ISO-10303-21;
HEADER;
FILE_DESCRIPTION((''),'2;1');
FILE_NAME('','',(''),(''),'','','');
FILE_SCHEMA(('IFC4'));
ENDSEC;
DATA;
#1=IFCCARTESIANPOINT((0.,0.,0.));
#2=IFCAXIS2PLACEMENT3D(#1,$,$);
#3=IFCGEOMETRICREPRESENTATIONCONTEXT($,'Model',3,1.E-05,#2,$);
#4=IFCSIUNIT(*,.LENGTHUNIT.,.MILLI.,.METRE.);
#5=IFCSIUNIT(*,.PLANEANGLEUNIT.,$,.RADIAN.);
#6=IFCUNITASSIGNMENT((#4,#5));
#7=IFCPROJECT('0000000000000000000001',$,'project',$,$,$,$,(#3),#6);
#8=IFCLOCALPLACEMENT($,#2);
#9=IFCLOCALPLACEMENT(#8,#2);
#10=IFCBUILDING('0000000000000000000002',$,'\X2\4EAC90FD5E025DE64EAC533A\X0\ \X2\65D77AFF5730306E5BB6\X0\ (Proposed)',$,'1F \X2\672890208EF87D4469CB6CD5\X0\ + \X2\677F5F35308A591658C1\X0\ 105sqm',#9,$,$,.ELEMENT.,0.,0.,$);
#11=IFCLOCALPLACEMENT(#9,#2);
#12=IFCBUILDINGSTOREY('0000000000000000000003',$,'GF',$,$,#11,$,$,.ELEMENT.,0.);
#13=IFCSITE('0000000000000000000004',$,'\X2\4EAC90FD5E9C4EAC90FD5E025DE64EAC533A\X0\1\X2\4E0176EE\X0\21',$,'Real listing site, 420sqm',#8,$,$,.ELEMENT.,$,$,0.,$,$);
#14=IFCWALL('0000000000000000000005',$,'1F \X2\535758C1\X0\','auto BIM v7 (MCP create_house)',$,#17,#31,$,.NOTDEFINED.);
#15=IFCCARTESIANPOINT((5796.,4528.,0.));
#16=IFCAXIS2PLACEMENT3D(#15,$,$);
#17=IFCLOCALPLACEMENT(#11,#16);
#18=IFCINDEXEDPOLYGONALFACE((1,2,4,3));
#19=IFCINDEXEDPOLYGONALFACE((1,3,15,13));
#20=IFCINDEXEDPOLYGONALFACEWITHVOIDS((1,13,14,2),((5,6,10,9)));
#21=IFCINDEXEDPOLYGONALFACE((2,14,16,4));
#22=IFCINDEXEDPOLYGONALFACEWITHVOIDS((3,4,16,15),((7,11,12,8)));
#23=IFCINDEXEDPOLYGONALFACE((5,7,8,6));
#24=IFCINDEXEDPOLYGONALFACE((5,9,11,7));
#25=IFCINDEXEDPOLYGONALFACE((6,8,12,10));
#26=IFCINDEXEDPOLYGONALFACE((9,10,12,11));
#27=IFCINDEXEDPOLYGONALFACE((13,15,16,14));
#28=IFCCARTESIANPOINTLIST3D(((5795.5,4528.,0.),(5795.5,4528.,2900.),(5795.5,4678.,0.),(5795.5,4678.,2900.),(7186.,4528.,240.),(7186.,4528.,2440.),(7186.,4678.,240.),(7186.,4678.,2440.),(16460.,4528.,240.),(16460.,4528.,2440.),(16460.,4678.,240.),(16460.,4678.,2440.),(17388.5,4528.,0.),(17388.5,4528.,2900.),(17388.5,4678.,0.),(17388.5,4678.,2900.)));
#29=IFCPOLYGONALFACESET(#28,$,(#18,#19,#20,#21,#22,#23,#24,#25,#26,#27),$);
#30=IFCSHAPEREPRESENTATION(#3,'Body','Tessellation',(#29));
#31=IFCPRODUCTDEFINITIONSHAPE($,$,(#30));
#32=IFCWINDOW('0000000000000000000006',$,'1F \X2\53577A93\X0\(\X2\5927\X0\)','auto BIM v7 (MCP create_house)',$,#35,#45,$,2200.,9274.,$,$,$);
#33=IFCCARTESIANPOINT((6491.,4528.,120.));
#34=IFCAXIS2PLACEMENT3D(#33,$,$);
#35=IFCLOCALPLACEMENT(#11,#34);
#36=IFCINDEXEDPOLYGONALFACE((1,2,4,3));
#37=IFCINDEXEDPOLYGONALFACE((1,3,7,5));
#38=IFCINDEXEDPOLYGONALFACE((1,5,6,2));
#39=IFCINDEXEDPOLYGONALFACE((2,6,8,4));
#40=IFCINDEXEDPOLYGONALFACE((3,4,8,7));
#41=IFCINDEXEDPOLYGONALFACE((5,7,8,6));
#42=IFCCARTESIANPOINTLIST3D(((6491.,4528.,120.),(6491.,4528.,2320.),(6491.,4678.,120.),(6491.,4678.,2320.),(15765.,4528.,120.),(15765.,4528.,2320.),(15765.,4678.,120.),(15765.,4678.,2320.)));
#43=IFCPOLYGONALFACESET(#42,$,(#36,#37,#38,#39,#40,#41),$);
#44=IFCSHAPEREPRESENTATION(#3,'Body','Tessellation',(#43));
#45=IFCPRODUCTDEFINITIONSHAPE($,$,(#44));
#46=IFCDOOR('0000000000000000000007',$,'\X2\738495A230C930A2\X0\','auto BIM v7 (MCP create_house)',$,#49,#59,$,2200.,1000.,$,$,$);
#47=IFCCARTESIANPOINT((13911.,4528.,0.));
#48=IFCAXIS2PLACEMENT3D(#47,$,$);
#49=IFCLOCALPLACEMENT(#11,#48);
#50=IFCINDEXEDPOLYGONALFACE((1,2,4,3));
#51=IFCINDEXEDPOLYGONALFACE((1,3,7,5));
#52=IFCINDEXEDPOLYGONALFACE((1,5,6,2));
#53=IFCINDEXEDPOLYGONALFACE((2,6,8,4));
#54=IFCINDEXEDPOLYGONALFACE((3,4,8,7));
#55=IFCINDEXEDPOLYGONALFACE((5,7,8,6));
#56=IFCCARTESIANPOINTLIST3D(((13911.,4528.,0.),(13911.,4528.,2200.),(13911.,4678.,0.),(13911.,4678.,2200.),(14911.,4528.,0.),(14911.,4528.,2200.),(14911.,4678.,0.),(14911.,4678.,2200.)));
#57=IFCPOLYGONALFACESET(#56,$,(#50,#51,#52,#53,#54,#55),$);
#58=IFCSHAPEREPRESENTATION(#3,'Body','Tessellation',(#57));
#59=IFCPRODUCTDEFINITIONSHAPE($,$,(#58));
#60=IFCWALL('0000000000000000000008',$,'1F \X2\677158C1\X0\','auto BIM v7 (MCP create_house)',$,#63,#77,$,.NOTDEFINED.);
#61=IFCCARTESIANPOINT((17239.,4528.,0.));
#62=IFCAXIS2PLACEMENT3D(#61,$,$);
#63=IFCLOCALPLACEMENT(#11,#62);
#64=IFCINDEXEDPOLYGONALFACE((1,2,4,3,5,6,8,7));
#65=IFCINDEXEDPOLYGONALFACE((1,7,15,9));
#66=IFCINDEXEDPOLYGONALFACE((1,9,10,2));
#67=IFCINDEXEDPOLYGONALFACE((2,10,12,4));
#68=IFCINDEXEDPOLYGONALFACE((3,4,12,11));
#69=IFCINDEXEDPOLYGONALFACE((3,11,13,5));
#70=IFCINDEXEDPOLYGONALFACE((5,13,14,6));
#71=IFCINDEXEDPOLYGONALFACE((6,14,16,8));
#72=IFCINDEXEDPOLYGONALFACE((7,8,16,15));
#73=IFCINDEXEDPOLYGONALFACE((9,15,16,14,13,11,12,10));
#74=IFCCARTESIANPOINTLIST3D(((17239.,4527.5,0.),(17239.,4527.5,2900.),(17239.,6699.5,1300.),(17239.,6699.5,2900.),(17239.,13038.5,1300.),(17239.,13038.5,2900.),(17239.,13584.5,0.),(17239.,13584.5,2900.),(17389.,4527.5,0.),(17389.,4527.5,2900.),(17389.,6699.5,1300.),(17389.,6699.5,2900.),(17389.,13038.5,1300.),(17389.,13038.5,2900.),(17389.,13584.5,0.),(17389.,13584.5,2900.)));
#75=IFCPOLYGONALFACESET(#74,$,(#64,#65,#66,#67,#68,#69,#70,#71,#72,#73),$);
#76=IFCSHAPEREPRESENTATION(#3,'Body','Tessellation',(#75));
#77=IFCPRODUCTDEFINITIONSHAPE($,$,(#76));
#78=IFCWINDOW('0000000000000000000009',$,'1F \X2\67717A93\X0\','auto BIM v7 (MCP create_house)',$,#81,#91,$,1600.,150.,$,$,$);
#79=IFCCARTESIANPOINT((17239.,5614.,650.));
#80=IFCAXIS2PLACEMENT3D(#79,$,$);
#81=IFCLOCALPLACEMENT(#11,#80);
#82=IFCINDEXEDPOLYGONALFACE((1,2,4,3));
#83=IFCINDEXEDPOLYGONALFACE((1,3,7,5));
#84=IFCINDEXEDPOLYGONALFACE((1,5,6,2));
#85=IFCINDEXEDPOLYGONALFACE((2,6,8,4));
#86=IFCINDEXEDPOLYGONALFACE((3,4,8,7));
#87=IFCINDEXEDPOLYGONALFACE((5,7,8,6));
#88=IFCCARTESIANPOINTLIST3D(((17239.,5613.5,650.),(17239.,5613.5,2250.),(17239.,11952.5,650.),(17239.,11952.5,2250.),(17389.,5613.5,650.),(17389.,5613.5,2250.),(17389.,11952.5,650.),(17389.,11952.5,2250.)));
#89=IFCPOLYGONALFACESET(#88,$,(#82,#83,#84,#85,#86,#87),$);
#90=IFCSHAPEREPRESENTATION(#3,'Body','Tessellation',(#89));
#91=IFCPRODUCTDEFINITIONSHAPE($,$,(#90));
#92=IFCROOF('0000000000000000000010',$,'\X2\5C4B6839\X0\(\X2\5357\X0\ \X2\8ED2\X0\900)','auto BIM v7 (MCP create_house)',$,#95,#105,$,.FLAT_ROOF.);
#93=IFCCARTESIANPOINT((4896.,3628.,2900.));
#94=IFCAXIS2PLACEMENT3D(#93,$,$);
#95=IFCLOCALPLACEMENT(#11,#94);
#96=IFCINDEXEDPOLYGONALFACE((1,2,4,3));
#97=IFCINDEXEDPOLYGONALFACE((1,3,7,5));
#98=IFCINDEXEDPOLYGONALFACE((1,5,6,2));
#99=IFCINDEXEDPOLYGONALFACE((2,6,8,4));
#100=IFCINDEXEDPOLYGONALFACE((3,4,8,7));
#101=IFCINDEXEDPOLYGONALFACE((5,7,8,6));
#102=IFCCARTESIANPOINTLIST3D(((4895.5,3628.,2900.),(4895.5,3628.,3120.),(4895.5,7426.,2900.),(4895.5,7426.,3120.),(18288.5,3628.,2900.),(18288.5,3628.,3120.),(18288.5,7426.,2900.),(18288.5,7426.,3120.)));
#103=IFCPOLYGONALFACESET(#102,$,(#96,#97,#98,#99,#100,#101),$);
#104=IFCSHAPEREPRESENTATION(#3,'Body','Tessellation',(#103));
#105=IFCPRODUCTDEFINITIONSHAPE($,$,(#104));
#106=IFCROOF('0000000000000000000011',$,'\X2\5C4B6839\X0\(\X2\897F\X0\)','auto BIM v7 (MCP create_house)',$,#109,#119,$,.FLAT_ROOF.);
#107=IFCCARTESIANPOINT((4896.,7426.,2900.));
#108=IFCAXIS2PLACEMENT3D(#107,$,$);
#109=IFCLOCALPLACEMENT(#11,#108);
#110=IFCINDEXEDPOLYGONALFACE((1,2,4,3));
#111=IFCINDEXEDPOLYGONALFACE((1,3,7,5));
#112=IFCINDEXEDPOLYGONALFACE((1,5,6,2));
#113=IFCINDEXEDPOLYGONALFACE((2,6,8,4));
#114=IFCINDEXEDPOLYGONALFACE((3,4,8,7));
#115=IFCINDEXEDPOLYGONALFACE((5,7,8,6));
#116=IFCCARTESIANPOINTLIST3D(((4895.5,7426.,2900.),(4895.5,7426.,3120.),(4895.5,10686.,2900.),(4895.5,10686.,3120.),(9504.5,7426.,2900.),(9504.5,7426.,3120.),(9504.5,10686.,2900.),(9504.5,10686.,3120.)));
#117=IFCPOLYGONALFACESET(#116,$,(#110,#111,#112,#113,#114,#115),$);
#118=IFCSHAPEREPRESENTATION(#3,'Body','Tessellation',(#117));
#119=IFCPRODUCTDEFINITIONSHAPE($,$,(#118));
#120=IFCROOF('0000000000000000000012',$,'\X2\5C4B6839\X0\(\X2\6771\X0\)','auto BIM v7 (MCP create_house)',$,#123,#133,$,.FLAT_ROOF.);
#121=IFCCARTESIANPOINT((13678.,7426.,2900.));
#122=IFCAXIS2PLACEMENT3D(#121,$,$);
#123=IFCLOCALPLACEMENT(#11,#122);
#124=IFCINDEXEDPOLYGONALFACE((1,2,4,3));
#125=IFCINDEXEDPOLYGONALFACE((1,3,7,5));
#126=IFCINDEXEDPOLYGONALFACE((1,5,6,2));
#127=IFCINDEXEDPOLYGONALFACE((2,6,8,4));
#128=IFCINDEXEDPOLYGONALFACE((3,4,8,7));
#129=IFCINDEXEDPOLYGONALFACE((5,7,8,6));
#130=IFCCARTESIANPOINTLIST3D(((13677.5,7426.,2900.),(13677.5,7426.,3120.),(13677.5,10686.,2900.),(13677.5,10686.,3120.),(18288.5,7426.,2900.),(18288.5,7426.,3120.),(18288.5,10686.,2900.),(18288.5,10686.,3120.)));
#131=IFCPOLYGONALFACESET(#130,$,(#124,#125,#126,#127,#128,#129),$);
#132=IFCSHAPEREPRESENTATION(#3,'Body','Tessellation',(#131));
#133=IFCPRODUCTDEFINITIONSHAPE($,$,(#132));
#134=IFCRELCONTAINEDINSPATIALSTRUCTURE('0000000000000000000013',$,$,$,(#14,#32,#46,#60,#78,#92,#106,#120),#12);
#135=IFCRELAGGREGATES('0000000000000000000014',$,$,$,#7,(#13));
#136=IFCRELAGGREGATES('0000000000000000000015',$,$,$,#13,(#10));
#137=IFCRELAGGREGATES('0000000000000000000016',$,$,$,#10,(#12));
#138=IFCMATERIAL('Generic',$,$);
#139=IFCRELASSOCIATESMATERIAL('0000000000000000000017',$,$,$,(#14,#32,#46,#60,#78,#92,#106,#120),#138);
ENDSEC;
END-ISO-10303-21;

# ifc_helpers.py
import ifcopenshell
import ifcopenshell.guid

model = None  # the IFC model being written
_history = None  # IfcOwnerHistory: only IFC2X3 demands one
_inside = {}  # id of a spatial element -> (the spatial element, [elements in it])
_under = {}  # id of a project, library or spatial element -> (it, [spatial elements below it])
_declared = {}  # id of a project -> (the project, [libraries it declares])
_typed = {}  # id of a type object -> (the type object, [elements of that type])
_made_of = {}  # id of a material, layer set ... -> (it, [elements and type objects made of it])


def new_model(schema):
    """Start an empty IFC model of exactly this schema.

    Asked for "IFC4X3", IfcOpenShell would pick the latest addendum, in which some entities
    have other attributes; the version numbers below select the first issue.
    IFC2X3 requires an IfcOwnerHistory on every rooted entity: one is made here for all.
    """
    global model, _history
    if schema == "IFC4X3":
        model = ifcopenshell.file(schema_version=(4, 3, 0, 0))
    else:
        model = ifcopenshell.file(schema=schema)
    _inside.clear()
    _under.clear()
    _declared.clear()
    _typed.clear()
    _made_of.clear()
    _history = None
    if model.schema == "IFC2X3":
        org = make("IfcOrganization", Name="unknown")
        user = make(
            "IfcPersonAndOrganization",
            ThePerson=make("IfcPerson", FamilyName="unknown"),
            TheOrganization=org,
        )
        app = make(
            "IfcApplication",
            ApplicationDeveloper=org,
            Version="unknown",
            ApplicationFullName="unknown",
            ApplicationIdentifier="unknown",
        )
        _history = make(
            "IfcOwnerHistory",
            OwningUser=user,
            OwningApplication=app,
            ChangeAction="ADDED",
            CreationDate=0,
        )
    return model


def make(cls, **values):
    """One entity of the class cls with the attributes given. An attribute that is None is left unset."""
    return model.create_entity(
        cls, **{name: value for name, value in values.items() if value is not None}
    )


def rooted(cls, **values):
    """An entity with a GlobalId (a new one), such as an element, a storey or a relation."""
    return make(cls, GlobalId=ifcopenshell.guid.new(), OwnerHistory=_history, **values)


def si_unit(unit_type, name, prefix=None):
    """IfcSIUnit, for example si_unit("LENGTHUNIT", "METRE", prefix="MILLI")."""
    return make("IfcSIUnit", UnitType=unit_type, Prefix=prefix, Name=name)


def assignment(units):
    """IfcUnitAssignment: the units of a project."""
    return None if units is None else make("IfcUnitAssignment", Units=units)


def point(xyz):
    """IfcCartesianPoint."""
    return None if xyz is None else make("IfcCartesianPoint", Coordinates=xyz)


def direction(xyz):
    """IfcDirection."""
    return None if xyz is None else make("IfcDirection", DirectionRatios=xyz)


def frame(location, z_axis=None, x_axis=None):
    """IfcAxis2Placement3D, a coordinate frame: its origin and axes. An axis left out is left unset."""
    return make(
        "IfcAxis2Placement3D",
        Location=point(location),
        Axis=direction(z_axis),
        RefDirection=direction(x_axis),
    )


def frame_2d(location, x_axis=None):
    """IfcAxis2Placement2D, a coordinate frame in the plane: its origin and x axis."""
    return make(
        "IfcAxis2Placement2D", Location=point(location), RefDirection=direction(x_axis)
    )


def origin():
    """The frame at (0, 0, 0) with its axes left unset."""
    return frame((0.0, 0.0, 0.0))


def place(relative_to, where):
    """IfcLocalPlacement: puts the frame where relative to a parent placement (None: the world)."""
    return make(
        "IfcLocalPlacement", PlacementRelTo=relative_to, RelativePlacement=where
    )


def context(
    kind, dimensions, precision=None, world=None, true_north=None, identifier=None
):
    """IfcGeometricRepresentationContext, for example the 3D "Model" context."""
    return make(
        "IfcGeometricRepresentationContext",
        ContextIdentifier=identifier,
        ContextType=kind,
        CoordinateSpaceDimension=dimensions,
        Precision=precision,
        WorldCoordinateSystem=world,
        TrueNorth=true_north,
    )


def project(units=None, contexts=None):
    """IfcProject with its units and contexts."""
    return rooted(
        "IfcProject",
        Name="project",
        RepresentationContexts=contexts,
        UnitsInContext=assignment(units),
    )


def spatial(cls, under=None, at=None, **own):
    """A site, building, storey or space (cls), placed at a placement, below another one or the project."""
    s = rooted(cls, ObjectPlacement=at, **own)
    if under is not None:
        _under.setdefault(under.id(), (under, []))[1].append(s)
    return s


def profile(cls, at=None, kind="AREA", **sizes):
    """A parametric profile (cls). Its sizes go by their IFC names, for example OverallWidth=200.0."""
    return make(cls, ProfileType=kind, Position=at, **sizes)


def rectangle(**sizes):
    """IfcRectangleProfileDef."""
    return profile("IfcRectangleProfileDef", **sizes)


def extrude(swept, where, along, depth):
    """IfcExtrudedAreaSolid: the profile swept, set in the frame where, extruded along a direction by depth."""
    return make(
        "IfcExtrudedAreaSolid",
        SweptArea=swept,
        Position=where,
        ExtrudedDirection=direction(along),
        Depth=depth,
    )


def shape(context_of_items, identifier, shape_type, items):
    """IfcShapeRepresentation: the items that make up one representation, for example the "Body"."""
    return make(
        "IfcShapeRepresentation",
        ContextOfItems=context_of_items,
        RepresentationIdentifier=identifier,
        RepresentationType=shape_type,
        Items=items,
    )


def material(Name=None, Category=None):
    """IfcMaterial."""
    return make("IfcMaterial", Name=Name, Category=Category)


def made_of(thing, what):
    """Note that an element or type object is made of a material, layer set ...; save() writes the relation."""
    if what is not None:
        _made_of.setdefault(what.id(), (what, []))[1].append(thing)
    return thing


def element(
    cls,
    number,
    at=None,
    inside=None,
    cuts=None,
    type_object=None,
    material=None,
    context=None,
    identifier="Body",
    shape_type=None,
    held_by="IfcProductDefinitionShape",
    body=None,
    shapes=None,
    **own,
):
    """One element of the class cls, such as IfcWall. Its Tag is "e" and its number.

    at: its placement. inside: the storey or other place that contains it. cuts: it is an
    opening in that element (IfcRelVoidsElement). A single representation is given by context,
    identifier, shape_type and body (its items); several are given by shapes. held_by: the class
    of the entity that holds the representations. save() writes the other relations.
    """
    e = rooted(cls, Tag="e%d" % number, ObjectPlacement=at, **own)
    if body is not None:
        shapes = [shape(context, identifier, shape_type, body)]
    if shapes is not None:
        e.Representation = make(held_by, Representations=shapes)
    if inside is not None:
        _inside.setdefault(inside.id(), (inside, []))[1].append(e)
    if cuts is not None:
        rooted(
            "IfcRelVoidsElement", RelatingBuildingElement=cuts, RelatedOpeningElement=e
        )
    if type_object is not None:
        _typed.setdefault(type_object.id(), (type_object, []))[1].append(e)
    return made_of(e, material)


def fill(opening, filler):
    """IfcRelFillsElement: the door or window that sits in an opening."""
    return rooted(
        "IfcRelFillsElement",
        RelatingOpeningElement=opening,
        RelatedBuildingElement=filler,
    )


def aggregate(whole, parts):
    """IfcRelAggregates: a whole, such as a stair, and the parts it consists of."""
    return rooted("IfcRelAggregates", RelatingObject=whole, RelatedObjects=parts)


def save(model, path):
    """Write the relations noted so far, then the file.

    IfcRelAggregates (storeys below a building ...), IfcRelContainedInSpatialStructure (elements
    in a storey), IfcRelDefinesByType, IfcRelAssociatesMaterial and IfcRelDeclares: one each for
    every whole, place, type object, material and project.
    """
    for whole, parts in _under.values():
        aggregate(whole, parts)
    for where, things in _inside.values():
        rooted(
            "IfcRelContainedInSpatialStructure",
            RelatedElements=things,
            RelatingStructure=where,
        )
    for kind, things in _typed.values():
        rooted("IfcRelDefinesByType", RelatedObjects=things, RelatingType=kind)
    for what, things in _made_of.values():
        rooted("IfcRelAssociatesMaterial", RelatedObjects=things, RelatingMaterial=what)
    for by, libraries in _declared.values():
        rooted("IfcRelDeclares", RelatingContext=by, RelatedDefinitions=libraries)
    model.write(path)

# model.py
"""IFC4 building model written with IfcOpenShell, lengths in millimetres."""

from ifc_helpers import new_model, si_unit, frame, frame_2d, origin, place, context, project, spatial, rectangle, extrude, material, element, fill, save


model = new_model("IFC4")

# Units and contexts
model_context = context("Model", 3, precision=1e-05, world=origin())
ifc_project = project(units=[si_unit("LENGTHUNIT", "METRE", prefix="MILLI"), si_unit("PLANEANGLEUNIT", "RADIAN")], contexts=[model_context])

# Site, building, storey
site_placement = place(None, origin())
site = spatial("IfcSite", under=ifc_project, at=site_placement, Name="京都府京都市左京区1丁目21", ObjectType="Real listing site, 420sqm", CompositionType="ELEMENT", RefElevation=0.0)
building_placement = place(site_placement, origin())
building = spatial("IfcBuilding", under=site, at=building_placement, Name="京都市左京区 旗竿地の家 (Proposed)", ObjectType="1F 木造軸組構法 + 板張り外壁 105sqm", CompositionType="ELEMENT", ElevationOfRefHeight=0.0, ElevationOfTerrain=0.0)
storey_placement = place(building_placement, origin())
storey = spatial("IfcBuildingStorey", under=building, at=storey_placement, Name="GF", CompositionType="ELEMENT", Elevation=0.0)

# Shared definitions
ifc_material = material(Name="Generic")

# Wall, openings, window, door
wall_1_placement = place(storey_placement, frame((5796.0, 4528.0, 0.0)))
wall_1 = element("IfcWall", 1, at=wall_1_placement, inside=storey, material=ifc_material, Name="1F 南壁", Description="auto BIM v7 (MCP create_house)", PredefinedType="NOTDEFINED", context=model_context, shape_type="SweptSolid", body=[
    extrude(rectangle(XDim=11593.0, YDim=150.0, at=frame_2d((5796.0, 75.0))), frame((5796.0, 4528.0, 0.0)), (0.0, 0.0, 1.0), 2900.0),
])
opening_1_placement = place(storey_placement, frame((6491.0, 4528.0, 120.0)))
opening_1 = element("IfcOpeningElement", 2, at=opening_1_placement, cuts=wall_1, PredefinedType="NOTDEFINED", context=model_context, shape_type="SweptSolid", body=[
    extrude(rectangle(XDim=9274.0, YDim=150.0, at=frame_2d((4637.0, 75.0))), frame((6491.0, 4528.0, 120.0)), (0.0, 0.0, 1.0), 2200.0),
])
opening_2_placement = place(storey_placement, frame((13911.0, 4528.0, 0.0)))
opening_2 = element("IfcOpeningElement", 3, at=opening_2_placement, cuts=wall_1, PredefinedType="NOTDEFINED", context=model_context, shape_type="SweptSolid", body=[
    extrude(rectangle(XDim=1000.0, YDim=150.0, at=frame_2d((500.0, 75.0))), frame((13911.0, 4528.0, 0.0)), (0.0, 0.0, 1.0), 2200.0),
])
window_1_placement = place(storey_placement, frame((6491.0, 4528.0, 120.0)))
window_1 = element("IfcWindow", 4, at=window_1_placement, inside=storey, material=ifc_material, Name="1F 南窓(大)", Description="auto BIM v7 (MCP create_house)", OverallHeight=2200.0, OverallWidth=9274.0, context=model_context, shape_type="SweptSolid", body=[
    extrude(rectangle(XDim=9274.0, YDim=150.0, at=frame_2d((4637.0, 75.0))), frame((6491.0, 4528.0, 120.0)), (0.0, 0.0, 1.0), 2200.0),
])
fill(opening_1, window_1)
door_placement = place(storey_placement, frame((13911.0, 4528.0, 0.0)))
door = element("IfcDoor", 5, at=door_placement, inside=storey, material=ifc_material, Name="玄関ドア", Description="auto BIM v7 (MCP create_house)", OverallHeight=2200.0, OverallWidth=1000.0, context=model_context, shape_type="SweptSolid", body=[
    extrude(rectangle(XDim=1000.0, YDim=150.0, at=frame_2d((500.0, 75.0))), frame((13911.0, 4528.0, 0.0)), (0.0, 0.0, 1.0), 2200.0),
])
fill(opening_2, door)

# Wall, opening, window
wall_2_placement = place(storey_placement, frame((17239.0, 4528.0, 0.0)))
wall_2 = element("IfcWall", 6, at=wall_2_placement, inside=storey, material=ifc_material, Name="1F 東壁", Description="auto BIM v7 (MCP create_house)", PredefinedType="NOTDEFINED", context=model_context, shape_type="SweptSolid", body=[
    extrude(rectangle(XDim=150.0, YDim=9057.0, at=frame_2d((75.0, 4528.0))), frame((17239.0, 4528.0, 0.0)), (0.0, 0.0, 1.0), 2900.0),
])
opening_3_placement = place(storey_placement, frame((17239.0, 5614.0, 650.0)))
opening_3 = element("IfcOpeningElement", 7, at=opening_3_placement, cuts=wall_2, PredefinedType="NOTDEFINED", context=model_context, shape_type="SweptSolid", body=[
    extrude(rectangle(XDim=150.0, YDim=6339.0, at=frame_2d((75.0, 3169.0))), frame((17239.0, 5614.0, 650.0)), (0.0, 0.0, 1.0), 1600.0),
])
window_2_placement = place(storey_placement, frame((17239.0, 5614.0, 650.0)))
window_2 = element("IfcWindow", 8, at=window_2_placement, inside=storey, material=ifc_material, Name="1F 東窓", Description="auto BIM v7 (MCP create_house)", OverallHeight=1600.0, OverallWidth=150.0, context=model_context, shape_type="SweptSolid", body=[
    extrude(rectangle(XDim=150.0, YDim=6339.0, at=frame_2d((75.0, 3169.0))), frame((17239.0, 5614.0, 650.0)), (0.0, 0.0, 1.0), 1600.0),
])
fill(opening_3, window_2)

# Roofs
roof_1_placement = place(storey_placement, frame((4896.0, 3628.0, 2900.0)))
element("IfcRoof", 9, at=roof_1_placement, inside=storey, material=ifc_material, Name="屋根(南 軒900)", Description="auto BIM v7 (MCP create_house)", PredefinedType="FLAT_ROOF", context=model_context, shape_type="SweptSolid", body=[
    extrude(rectangle(XDim=13393.0, YDim=3798.0, at=frame_2d((6696.0, 1899.0))), frame((4896.0, 3628.0, 2900.0)), (0.0, 0.0, 1.0), 220.0),
])
roof_2_placement = place(storey_placement, frame((4896.0, 7426.0, 2900.0)))
element("IfcRoof", 10, at=roof_2_placement, inside=storey, material=ifc_material, Name="屋根(西)", Description="auto BIM v7 (MCP create_house)", PredefinedType="FLAT_ROOF", context=model_context, shape_type="SweptSolid", body=[
    extrude(rectangle(XDim=4609.0, YDim=3260.0, at=frame_2d((2304.0, 1630.0))), frame((4896.0, 7426.0, 2900.0)), (0.0, 0.0, 1.0), 220.0),
])
roof_3_placement = place(storey_placement, frame((13678.0, 7426.0, 2900.0)))
element("IfcRoof", 11, at=roof_3_placement, inside=storey, material=ifc_material, Name="屋根(東)", Description="auto BIM v7 (MCP create_house)", PredefinedType="FLAT_ROOF", context=model_context, shape_type="SweptSolid", body=[
    extrude(rectangle(XDim=4611.0, YDim=3260.0, at=frame_2d((2305.0, 1630.0))), frame((13678.0, 7426.0, 2900.0)), (0.0, 0.0, 1.0), 220.0),
])

save(model, "model.ifc")
